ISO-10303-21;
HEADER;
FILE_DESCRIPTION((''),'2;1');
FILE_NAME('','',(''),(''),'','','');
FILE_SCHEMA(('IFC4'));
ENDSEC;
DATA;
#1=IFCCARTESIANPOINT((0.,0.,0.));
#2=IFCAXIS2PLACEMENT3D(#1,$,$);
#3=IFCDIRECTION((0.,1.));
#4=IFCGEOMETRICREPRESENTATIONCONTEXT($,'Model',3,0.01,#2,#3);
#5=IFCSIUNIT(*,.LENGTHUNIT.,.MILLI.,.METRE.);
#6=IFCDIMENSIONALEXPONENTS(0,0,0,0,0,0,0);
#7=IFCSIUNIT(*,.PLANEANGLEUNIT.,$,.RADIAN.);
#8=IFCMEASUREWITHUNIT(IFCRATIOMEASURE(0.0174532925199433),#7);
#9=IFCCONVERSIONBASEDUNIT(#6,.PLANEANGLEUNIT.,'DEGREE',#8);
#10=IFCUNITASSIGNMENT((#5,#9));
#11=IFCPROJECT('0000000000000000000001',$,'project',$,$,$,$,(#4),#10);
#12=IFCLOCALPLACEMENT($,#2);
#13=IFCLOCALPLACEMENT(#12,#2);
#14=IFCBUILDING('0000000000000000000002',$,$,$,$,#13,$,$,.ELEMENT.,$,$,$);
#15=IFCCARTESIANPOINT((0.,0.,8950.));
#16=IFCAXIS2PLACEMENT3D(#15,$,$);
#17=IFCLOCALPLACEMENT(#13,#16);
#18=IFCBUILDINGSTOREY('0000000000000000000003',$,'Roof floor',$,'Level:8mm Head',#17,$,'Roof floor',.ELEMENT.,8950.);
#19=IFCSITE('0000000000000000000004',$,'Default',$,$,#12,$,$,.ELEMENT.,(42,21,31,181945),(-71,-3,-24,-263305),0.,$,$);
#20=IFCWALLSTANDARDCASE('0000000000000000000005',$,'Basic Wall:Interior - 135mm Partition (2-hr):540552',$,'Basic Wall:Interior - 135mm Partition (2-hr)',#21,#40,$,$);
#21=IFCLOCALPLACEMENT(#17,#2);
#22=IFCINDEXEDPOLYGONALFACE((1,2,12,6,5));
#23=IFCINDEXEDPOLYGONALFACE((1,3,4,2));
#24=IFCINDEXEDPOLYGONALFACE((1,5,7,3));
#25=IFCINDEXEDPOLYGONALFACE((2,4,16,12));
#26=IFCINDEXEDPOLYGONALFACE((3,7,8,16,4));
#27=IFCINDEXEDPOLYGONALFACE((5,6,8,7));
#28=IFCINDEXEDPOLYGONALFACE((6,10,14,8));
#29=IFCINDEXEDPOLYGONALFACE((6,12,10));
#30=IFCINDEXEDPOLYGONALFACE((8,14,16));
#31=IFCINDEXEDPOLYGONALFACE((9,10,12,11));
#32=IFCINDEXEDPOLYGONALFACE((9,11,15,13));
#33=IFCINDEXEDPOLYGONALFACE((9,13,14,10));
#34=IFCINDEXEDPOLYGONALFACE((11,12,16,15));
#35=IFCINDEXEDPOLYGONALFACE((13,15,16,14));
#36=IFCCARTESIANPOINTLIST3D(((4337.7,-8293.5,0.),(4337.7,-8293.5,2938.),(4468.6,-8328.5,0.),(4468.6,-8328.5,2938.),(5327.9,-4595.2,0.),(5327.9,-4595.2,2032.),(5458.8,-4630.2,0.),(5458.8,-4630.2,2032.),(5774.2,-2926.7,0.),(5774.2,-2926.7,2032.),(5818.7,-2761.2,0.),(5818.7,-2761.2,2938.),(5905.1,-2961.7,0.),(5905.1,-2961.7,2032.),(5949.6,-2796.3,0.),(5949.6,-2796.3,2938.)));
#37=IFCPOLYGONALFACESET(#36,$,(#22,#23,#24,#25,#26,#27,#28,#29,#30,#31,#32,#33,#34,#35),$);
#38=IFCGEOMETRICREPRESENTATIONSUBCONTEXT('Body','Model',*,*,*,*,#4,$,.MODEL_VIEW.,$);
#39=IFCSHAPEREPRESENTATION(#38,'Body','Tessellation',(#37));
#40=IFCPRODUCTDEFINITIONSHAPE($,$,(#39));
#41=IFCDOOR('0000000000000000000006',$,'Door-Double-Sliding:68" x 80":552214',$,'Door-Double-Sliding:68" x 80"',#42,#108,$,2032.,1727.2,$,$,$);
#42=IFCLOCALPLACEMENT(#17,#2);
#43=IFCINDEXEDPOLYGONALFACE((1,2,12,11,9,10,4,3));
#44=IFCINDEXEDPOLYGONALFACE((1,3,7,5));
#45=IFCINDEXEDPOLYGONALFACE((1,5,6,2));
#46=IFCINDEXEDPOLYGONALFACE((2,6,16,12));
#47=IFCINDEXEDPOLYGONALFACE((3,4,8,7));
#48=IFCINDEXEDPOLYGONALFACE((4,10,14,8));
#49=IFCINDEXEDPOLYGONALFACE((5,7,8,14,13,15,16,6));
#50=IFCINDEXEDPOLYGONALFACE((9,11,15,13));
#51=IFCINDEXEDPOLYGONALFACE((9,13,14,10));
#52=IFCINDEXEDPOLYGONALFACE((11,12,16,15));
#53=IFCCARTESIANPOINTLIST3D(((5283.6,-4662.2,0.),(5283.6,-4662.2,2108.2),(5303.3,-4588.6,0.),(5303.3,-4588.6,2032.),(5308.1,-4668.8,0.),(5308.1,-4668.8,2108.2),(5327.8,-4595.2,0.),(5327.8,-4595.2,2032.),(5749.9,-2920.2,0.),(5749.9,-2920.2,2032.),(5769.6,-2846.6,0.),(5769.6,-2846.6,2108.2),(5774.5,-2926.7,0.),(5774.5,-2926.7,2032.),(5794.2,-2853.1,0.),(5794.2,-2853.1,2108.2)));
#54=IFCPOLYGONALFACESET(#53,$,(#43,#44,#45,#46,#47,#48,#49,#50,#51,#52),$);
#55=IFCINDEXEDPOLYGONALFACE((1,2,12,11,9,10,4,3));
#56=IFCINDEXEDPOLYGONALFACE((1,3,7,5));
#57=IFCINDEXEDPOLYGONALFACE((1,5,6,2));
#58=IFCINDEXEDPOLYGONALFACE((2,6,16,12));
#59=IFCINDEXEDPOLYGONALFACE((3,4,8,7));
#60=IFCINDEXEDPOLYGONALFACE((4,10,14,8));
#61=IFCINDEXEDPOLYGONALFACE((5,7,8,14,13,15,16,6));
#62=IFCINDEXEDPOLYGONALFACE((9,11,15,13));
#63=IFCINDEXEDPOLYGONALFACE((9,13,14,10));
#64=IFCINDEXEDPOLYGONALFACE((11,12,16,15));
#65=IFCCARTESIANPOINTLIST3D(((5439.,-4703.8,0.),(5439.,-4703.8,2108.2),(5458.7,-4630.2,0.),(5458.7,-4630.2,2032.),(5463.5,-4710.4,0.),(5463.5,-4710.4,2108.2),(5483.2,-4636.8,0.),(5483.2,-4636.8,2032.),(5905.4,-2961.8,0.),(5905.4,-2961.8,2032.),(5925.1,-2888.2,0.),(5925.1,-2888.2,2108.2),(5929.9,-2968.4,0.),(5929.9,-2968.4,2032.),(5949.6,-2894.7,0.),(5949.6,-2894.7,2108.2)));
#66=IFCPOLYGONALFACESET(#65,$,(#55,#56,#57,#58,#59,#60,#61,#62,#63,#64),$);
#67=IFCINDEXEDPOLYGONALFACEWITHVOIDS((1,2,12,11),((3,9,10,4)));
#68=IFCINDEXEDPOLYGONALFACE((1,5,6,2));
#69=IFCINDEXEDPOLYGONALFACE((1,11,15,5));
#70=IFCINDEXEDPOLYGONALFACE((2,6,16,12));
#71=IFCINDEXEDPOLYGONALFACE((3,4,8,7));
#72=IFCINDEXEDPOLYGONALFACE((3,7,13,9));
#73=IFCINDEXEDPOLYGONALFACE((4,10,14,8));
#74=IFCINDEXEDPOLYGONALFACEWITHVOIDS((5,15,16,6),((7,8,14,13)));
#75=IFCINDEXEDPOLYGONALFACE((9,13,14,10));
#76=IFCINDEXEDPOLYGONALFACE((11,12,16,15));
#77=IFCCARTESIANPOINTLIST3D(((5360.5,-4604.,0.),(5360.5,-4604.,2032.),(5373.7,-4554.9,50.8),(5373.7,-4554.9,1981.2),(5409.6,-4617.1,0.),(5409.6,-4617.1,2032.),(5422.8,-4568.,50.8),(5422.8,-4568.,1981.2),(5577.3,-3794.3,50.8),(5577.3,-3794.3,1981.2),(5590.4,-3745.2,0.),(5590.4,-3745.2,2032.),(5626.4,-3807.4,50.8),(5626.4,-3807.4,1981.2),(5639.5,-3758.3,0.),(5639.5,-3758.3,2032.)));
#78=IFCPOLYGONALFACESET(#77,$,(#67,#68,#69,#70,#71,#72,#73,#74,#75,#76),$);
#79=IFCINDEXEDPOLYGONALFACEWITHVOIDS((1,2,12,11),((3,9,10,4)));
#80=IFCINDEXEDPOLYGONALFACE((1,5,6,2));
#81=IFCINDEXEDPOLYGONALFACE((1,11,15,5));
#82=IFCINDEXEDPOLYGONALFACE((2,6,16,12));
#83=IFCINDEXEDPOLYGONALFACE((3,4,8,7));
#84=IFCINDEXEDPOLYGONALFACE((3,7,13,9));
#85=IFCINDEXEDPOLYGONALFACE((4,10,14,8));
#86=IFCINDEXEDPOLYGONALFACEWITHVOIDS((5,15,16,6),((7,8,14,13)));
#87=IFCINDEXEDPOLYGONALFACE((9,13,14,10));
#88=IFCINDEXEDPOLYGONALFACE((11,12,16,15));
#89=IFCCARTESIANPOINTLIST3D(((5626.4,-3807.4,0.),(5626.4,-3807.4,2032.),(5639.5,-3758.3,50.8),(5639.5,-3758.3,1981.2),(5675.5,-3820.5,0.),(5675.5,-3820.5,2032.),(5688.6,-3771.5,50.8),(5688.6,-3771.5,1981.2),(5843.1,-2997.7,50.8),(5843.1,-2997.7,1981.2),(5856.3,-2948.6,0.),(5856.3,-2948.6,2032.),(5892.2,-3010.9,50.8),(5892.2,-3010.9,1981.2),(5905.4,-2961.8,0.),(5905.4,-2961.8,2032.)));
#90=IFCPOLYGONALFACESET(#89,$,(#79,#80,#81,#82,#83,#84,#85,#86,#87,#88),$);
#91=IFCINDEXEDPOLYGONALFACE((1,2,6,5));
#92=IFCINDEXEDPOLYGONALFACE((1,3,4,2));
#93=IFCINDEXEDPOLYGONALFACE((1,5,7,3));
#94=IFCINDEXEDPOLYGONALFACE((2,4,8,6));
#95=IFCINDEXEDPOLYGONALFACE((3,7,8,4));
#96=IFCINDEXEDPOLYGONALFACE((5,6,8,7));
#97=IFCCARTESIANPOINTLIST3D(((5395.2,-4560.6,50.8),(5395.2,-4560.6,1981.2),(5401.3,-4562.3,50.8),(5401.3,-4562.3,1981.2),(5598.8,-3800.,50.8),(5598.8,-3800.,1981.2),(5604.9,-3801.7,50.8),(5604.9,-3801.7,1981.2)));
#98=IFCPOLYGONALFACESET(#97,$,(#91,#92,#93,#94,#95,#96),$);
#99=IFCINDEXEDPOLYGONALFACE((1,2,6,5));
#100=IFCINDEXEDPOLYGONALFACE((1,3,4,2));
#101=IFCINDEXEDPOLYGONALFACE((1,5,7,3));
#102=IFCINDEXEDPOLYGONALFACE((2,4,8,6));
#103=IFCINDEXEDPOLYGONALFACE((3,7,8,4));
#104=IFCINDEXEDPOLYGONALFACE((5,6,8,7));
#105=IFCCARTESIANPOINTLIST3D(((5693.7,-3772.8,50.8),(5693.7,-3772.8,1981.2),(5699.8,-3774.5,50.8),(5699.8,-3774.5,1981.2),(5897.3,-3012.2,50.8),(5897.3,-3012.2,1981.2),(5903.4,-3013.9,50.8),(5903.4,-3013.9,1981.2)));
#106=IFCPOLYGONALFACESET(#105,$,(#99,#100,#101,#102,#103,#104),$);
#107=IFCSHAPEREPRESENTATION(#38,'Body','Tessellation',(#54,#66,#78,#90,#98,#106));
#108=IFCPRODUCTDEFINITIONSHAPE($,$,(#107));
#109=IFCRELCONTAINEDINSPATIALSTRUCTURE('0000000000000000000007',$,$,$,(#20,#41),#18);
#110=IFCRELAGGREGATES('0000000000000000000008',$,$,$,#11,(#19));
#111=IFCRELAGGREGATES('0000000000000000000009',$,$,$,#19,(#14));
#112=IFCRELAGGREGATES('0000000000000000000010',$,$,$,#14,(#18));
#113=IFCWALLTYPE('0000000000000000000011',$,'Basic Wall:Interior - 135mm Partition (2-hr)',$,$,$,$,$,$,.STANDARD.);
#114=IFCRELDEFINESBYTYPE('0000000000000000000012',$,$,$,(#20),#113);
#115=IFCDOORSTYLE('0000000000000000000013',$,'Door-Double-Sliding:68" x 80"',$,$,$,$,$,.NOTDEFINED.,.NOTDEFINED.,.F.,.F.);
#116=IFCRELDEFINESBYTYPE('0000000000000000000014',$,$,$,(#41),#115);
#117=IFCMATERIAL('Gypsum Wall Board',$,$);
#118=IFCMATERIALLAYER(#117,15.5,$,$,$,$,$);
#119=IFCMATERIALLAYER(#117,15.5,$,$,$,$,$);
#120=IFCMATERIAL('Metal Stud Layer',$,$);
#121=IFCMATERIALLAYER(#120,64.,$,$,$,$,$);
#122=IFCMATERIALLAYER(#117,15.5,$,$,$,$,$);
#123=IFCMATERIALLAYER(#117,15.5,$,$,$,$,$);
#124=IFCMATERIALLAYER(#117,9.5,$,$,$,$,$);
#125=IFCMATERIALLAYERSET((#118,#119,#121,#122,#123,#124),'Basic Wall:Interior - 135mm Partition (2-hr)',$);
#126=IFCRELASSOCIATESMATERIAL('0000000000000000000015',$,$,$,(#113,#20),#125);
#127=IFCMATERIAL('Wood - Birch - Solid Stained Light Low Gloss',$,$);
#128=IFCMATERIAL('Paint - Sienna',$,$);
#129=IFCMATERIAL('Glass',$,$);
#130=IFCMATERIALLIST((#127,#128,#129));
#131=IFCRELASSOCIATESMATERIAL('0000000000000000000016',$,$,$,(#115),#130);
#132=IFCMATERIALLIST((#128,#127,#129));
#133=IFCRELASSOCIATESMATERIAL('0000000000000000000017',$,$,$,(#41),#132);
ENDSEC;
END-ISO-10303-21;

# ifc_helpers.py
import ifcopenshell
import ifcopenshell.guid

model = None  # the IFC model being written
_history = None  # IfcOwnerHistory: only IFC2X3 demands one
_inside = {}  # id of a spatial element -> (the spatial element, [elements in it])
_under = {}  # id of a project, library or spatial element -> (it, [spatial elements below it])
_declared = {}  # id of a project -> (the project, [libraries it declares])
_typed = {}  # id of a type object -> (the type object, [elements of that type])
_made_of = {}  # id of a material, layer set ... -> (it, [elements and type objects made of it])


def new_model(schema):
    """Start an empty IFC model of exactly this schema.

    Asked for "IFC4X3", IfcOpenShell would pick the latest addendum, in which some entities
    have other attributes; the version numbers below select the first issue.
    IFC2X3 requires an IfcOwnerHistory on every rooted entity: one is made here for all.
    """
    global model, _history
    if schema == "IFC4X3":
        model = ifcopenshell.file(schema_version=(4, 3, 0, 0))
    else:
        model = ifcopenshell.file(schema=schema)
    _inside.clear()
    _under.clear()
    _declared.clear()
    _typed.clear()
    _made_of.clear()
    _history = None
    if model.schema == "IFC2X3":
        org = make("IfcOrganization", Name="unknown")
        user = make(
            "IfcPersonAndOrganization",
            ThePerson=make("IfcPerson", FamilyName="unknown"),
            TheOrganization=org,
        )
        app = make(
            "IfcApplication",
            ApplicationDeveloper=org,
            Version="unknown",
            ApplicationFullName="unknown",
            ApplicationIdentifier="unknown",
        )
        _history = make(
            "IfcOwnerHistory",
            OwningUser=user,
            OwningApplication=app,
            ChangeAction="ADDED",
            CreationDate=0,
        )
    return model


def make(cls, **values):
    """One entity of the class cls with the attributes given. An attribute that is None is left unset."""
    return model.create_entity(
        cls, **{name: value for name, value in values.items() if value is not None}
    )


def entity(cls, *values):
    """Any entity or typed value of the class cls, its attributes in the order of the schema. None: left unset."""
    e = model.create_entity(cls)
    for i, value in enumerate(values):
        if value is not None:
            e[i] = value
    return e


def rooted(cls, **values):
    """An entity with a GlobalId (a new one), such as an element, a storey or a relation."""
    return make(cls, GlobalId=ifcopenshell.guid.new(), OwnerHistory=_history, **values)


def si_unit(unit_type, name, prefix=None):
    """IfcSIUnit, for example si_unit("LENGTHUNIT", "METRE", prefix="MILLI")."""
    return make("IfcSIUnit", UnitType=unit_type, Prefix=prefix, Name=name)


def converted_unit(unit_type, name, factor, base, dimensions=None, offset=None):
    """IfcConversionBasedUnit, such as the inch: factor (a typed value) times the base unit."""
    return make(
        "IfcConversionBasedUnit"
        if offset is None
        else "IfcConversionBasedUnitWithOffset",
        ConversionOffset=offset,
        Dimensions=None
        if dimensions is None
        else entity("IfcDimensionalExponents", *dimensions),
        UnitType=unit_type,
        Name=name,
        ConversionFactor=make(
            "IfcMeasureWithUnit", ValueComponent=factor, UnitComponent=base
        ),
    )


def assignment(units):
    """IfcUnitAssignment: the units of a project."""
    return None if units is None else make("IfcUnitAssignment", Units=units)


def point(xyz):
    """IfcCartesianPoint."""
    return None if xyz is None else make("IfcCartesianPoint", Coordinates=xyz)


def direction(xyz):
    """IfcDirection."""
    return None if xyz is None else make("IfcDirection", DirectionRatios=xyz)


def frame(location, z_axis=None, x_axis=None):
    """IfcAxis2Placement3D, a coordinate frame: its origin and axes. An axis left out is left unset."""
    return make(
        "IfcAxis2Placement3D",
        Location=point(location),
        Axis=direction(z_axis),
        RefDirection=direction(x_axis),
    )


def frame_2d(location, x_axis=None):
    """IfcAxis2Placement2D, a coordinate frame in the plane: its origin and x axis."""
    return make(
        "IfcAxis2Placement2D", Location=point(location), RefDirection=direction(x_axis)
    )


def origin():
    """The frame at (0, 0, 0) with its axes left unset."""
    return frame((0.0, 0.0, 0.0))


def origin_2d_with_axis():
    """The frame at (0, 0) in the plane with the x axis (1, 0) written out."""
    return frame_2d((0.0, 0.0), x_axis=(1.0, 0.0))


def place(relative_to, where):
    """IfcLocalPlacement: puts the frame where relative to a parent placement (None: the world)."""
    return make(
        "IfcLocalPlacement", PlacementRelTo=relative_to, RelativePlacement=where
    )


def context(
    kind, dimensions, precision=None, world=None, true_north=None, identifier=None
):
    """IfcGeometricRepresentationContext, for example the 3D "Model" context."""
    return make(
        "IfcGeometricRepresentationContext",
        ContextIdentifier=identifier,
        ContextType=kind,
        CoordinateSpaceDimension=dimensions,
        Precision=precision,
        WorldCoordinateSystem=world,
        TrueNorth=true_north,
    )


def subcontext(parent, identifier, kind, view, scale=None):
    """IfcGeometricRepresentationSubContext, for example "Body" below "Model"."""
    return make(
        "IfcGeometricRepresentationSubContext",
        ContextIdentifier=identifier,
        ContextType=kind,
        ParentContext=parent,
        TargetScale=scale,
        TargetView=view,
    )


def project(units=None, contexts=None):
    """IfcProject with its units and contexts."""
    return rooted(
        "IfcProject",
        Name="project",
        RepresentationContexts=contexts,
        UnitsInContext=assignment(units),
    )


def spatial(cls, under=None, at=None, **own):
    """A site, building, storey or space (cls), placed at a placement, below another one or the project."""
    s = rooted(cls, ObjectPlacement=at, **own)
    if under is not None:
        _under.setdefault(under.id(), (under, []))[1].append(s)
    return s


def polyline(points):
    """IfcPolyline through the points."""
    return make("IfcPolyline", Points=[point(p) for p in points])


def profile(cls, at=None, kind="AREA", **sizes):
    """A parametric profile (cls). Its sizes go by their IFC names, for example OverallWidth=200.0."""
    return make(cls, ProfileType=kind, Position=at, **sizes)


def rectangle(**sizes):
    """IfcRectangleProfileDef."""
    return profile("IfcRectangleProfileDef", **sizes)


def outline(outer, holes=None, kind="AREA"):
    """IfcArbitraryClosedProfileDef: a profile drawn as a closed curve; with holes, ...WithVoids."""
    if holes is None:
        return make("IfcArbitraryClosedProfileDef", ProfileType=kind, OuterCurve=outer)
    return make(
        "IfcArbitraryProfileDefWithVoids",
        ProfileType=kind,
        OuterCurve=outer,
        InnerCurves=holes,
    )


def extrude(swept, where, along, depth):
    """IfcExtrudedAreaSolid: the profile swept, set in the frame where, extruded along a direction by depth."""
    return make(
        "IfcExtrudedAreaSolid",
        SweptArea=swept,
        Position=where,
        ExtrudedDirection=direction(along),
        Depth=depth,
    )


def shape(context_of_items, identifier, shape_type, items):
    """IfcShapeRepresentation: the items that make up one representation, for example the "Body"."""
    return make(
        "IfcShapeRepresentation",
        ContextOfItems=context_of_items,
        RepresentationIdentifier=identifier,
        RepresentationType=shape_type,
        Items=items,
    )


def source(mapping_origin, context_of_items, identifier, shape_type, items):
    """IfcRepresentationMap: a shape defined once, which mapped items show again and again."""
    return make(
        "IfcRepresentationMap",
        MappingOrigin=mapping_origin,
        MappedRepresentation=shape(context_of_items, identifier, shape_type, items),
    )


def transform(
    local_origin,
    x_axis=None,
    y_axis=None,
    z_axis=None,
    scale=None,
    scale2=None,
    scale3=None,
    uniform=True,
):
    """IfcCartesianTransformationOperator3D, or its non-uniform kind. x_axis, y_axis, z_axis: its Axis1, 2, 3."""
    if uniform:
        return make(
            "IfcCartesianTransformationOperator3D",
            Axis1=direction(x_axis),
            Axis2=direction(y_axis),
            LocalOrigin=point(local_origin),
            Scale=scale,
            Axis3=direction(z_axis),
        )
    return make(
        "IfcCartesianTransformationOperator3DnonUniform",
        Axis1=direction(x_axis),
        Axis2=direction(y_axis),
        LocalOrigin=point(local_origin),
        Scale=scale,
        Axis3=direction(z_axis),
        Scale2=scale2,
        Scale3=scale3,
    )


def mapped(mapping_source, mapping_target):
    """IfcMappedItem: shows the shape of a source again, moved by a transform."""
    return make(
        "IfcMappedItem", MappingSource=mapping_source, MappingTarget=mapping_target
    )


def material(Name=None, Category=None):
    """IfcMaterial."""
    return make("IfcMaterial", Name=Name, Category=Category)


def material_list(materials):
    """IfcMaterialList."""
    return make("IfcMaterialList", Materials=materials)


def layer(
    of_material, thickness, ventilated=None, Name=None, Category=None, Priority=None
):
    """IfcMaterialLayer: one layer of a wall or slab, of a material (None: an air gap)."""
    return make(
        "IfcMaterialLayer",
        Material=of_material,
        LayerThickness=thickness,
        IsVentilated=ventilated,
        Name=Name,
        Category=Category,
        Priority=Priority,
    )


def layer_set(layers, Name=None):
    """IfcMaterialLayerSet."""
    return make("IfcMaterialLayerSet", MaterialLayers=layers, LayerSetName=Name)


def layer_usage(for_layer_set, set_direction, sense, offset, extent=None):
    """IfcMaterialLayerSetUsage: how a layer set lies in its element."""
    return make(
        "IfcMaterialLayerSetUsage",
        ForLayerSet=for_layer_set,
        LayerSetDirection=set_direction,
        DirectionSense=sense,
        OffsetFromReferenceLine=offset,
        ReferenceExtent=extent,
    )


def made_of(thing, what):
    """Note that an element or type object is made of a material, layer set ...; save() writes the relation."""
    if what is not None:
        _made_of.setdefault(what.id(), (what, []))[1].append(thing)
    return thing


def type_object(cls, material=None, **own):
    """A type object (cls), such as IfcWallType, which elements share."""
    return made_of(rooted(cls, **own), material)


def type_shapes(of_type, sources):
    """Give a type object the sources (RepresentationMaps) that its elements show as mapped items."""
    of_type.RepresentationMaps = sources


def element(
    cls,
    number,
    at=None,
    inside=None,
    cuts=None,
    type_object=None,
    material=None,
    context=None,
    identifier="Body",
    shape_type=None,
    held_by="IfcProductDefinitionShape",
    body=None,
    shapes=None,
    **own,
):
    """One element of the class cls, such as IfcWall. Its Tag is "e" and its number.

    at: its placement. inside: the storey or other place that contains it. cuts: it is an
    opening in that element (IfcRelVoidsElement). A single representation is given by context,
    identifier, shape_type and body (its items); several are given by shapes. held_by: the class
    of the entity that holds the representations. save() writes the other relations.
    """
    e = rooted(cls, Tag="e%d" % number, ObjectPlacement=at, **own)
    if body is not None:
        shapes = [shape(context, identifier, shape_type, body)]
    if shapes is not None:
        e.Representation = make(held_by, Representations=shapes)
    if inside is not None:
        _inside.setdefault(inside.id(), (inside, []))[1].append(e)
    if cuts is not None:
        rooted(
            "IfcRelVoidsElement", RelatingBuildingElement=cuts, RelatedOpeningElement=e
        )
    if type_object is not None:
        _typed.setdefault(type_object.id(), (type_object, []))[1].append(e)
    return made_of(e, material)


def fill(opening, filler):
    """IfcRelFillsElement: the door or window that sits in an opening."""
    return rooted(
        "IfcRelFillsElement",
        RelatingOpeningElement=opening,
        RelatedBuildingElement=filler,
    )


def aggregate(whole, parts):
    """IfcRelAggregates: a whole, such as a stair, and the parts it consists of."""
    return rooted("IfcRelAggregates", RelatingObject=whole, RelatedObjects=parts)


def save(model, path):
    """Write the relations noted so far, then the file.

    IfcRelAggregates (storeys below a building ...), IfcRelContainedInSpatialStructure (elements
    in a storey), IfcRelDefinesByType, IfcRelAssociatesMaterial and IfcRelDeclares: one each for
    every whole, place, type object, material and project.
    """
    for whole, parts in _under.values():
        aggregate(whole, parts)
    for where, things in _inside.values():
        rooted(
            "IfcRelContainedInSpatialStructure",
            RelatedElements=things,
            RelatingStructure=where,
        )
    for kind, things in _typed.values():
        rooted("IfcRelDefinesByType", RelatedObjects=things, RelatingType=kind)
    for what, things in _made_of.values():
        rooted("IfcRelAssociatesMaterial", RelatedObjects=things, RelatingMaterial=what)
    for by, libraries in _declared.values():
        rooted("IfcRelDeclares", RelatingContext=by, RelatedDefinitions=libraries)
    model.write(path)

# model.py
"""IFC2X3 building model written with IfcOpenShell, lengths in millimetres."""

from ifc_helpers import new_model, entity, si_unit, converted_unit, direction, frame, frame_2d, origin, origin_2d_with_axis, place, context, subcontext, project, spatial, polyline, rectangle, outline, extrude, source, transform, mapped, material, material_list, layer, layer_set, layer_usage, type_object, type_shapes, element, fill, save


model = new_model("IFC2X3")

# Units and contexts
model_context = context("Model", 3, precision=0.01, world=origin(), true_north=direction((0.0, 1.0)))
body_context = subcontext(model_context, "Body", "Model", "MODEL_VIEW")
ifc_project = project(units=[si_unit("LENGTHUNIT", "METRE", prefix="MILLI"), converted_unit("PLANEANGLEUNIT", "DEGREE", entity("IfcRatioMeasure", 0.0174532925199433), si_unit("PLANEANGLEUNIT", "RADIAN"), dimensions=[0, 0, 0, 0, 0, 0, 0])], contexts=[model_context])

# Site, building, storey
site_placement = place(None, origin())
site = spatial("IfcSite", under=ifc_project, at=site_placement, Name="Default", CompositionType="ELEMENT", RefLatitude=(42, 21, 31, 181945), RefLongitude=(-71, -3, -24, -263305), RefElevation=0.0)
building_placement = place(site_placement, origin())
building = spatial("IfcBuilding", under=site, at=building_placement, CompositionType="ELEMENT")
storey_placement = place(building_placement, frame((0.0, 0.0, 8950.0)))
storey = spatial("IfcBuildingStorey", under=building, at=storey_placement, Name="Roof floor", ObjectType="Level:8mm Head", LongName="Roof floor", CompositionType="ELEMENT", Elevation=8950.0)

# Shared definitions
ifc_material_1 = material(Name="Glass")

# Shared definitions
ifc_material_2 = material(Name="Gypsum Wall Board")

# Wall, opening, door
ifc_layer_1 = layer(ifc_material_2, 15.5)
ifc_layer_2 = layer(ifc_material_2, 15.5)
ifc_material_3 = material(Name="Metal Stud Layer")
ifc_layer_3 = layer(ifc_material_3, 64.0)
ifc_layer_4 = layer(ifc_material_2, 15.5)
ifc_layer_5 = layer(ifc_material_2, 15.5)
ifc_layer_6 = layer(ifc_material_2, 9.5)
ifc_layer_set_1 = layer_set([ifc_layer_1, ifc_layer_2, ifc_layer_3, ifc_layer_4, ifc_layer_5, ifc_layer_6], Name="Basic Wall:Interior - 135mm Partition (2-hr)")
ifc_layer_usage_1 = layer_usage(ifc_layer_set_1, "AXIS2", "NEGATIVE", 67.8)
wall_type_1 = type_object("IfcWallType", Name="Basic Wall:Interior - 135mm Partition (2-hr)", PredefinedType="STANDARD", material=ifc_layer_set_1)
wall_1_placement = place(storey_placement, frame((5884.2, -2778.7, 0.0), z_axis=(0.0, 0.0, 1.0), x_axis=(-0.258607, -0.965983, 0.0)))
wall_1 = element("IfcWallStandardCase", 1, at=wall_1_placement, inside=storey, type_object=wall_type_1, material=ifc_layer_usage_1, Name="Basic Wall:Interior - 135mm Partition (2-hr):540552", ObjectType="Basic Wall:Interior - 135mm Partition (2-hr)", context=body_context, shape_type="SweptSolid", body=[
    extrude(rectangle(XDim=5727.1, YDim=135.5, at=frame_2d((2863.5, 0.0), x_axis=(-1.0, 0.0))), origin(), (0.0, 0.0, 1.0), 2938.0),
])
opening_placement = place(wall_1_placement, frame((171.3, -67.9, 0.0)))
opening = element("IfcOpeningElement", 2, at=opening_placement, cuts=wall_1, ObjectType="Opening", context=body_context, shape_type="SweptSolid", body=[
    extrude(rectangle(XDim=2032.0, YDim=1727.2, at=frame_2d((1016.0, 863.6), x_axis=(-1.0, 0.0))), frame((0.0, 0.0, 0.0), z_axis=(-0.00022, 1.0, 0.0), x_axis=(0.0, 0.0, 1.0)), (0.0, 0.0, 1.0), 135.5),
])
ifc_material_4 = material(Name="Paint - Sienna")
ifc_material_5 = material(Name="Wood - Birch - Solid Stained Light Low Gloss")
ifc_material_list_1 = material_list([ifc_material_4, ifc_material_5, ifc_material_1])
ifc_material_list_2 = material_list([ifc_material_5, ifc_material_4, ifc_material_1])
door_style = type_object("IfcDoorStyle", Name="Door-Double-Sliding:68\" x 80\"", ConstructionType="NOTDEFINED", OperationType="NOTDEFINED", ParameterTakesPrecedence=False, Sizeable=False, material=ifc_material_list_2)
shared_shape_1 = source(origin(), body_context, "Body", "SweptSolid", [
    extrude(outline(polyline([(-1035.0, -939.8), (1073.2, -939.8), (1073.2, 939.8), (-1035.0, 939.8), (-1035.0, 863.6), (996.9, 863.6), (996.9, -863.6), (-1035.0, -863.6), (-1035.0, -939.8)])), frame((863.6, -25.4, 1035.0), z_axis=(0.0, 1.0, 0.0), x_axis=(0.0, 0.0, 1.0)), (0.0, 0.0, 1.0), 25.4),
    extrude(outline(polyline([(-939.8, -1035.0), (-863.6, -1035.0), (-863.6, 997.0), (863.6, 997.0), (863.6, -1035.0), (939.8, -1035.0), (939.8, 1073.2), (-939.8, 1073.2), (-939.8, -1035.0)])), frame((863.6, 135.5, 1035.0), z_axis=(0.0, 1.0, 0.0), x_axis=(-1.0, 0.0, 0.0)), (0.0, 0.0, 1.0), 25.4),
    extrude(outline(polyline([(-444.5, -1016.0), (444.5, -1016.0), (444.5, 1016.0), (-444.5, 1016.0), (-444.5, -1016.0)]), holes=[polyline([(-393.7, -965.2), (-393.7, 965.2), (393.7, 965.2), (393.7, -965.2), (-393.7, -965.2)])]), frame((1282.7, 33.9, 1016.0), z_axis=(0.0, 1.0, 0.0), x_axis=(1.0, 0.0, 0.0)), (0.0, 0.0, 1.0), 50.8),
    extrude(outline(polyline([(-1016.0, -444.5), (1016.0, -444.5), (1016.0, 444.5), (-1016.0, 444.5), (-1016.0, -444.5)]), holes=[polyline([(-965.2, -393.7), (-965.2, 393.7), (965.2, 393.7), (965.2, -393.7), (-965.2, -393.7)])]), frame((444.5, 84.7, 1016.0), z_axis=(0.0, 1.0, 0.0), x_axis=(0.0, 0.0, -1.0)), (0.0, 0.0, 1.0), 50.8),
    extrude(rectangle(XDim=6.3, YDim=787.4, at=origin_2d_with_axis()), frame((1282.7, 59.3, 50.8), z_axis=(0.0, 0.0, 1.0), x_axis=(0.0, -1.0, 0.0)), (0.0, 0.0, 1.0), 1930.4),
    extrude(rectangle(XDim=6.4, YDim=787.4, at=frame_2d((0.0, 0.0), x_axis=(1.0, 0.0))), frame((444.5, 144.0, 50.8), z_axis=(0.0, 0.0, 1.0), x_axis=(0.0, 1.0, 0.0)), (0.0, 0.0, 1.0), 1930.4),
])
type_shapes(door_style, [shared_shape_1])
door_placement = place(opening_placement, frame((0.0, 0.2, 0.0)))
door = element("IfcDoor", 3, at=door_placement, inside=storey, type_object=door_style, material=ifc_material_list_1, Name="Door-Double-Sliding:68\" x 80\":552214", ObjectType="Door-Double-Sliding:68\" x 80\"", OverallHeight=2032.0, OverallWidth=1727.2, context=body_context, shape_type="MappedRepresentation", body=[
    mapped(shared_shape_1, transform((0.0, 0.0, 0.0), scale=1.0)),
])
fill(opening, door)

save(model, "model.ifc")
